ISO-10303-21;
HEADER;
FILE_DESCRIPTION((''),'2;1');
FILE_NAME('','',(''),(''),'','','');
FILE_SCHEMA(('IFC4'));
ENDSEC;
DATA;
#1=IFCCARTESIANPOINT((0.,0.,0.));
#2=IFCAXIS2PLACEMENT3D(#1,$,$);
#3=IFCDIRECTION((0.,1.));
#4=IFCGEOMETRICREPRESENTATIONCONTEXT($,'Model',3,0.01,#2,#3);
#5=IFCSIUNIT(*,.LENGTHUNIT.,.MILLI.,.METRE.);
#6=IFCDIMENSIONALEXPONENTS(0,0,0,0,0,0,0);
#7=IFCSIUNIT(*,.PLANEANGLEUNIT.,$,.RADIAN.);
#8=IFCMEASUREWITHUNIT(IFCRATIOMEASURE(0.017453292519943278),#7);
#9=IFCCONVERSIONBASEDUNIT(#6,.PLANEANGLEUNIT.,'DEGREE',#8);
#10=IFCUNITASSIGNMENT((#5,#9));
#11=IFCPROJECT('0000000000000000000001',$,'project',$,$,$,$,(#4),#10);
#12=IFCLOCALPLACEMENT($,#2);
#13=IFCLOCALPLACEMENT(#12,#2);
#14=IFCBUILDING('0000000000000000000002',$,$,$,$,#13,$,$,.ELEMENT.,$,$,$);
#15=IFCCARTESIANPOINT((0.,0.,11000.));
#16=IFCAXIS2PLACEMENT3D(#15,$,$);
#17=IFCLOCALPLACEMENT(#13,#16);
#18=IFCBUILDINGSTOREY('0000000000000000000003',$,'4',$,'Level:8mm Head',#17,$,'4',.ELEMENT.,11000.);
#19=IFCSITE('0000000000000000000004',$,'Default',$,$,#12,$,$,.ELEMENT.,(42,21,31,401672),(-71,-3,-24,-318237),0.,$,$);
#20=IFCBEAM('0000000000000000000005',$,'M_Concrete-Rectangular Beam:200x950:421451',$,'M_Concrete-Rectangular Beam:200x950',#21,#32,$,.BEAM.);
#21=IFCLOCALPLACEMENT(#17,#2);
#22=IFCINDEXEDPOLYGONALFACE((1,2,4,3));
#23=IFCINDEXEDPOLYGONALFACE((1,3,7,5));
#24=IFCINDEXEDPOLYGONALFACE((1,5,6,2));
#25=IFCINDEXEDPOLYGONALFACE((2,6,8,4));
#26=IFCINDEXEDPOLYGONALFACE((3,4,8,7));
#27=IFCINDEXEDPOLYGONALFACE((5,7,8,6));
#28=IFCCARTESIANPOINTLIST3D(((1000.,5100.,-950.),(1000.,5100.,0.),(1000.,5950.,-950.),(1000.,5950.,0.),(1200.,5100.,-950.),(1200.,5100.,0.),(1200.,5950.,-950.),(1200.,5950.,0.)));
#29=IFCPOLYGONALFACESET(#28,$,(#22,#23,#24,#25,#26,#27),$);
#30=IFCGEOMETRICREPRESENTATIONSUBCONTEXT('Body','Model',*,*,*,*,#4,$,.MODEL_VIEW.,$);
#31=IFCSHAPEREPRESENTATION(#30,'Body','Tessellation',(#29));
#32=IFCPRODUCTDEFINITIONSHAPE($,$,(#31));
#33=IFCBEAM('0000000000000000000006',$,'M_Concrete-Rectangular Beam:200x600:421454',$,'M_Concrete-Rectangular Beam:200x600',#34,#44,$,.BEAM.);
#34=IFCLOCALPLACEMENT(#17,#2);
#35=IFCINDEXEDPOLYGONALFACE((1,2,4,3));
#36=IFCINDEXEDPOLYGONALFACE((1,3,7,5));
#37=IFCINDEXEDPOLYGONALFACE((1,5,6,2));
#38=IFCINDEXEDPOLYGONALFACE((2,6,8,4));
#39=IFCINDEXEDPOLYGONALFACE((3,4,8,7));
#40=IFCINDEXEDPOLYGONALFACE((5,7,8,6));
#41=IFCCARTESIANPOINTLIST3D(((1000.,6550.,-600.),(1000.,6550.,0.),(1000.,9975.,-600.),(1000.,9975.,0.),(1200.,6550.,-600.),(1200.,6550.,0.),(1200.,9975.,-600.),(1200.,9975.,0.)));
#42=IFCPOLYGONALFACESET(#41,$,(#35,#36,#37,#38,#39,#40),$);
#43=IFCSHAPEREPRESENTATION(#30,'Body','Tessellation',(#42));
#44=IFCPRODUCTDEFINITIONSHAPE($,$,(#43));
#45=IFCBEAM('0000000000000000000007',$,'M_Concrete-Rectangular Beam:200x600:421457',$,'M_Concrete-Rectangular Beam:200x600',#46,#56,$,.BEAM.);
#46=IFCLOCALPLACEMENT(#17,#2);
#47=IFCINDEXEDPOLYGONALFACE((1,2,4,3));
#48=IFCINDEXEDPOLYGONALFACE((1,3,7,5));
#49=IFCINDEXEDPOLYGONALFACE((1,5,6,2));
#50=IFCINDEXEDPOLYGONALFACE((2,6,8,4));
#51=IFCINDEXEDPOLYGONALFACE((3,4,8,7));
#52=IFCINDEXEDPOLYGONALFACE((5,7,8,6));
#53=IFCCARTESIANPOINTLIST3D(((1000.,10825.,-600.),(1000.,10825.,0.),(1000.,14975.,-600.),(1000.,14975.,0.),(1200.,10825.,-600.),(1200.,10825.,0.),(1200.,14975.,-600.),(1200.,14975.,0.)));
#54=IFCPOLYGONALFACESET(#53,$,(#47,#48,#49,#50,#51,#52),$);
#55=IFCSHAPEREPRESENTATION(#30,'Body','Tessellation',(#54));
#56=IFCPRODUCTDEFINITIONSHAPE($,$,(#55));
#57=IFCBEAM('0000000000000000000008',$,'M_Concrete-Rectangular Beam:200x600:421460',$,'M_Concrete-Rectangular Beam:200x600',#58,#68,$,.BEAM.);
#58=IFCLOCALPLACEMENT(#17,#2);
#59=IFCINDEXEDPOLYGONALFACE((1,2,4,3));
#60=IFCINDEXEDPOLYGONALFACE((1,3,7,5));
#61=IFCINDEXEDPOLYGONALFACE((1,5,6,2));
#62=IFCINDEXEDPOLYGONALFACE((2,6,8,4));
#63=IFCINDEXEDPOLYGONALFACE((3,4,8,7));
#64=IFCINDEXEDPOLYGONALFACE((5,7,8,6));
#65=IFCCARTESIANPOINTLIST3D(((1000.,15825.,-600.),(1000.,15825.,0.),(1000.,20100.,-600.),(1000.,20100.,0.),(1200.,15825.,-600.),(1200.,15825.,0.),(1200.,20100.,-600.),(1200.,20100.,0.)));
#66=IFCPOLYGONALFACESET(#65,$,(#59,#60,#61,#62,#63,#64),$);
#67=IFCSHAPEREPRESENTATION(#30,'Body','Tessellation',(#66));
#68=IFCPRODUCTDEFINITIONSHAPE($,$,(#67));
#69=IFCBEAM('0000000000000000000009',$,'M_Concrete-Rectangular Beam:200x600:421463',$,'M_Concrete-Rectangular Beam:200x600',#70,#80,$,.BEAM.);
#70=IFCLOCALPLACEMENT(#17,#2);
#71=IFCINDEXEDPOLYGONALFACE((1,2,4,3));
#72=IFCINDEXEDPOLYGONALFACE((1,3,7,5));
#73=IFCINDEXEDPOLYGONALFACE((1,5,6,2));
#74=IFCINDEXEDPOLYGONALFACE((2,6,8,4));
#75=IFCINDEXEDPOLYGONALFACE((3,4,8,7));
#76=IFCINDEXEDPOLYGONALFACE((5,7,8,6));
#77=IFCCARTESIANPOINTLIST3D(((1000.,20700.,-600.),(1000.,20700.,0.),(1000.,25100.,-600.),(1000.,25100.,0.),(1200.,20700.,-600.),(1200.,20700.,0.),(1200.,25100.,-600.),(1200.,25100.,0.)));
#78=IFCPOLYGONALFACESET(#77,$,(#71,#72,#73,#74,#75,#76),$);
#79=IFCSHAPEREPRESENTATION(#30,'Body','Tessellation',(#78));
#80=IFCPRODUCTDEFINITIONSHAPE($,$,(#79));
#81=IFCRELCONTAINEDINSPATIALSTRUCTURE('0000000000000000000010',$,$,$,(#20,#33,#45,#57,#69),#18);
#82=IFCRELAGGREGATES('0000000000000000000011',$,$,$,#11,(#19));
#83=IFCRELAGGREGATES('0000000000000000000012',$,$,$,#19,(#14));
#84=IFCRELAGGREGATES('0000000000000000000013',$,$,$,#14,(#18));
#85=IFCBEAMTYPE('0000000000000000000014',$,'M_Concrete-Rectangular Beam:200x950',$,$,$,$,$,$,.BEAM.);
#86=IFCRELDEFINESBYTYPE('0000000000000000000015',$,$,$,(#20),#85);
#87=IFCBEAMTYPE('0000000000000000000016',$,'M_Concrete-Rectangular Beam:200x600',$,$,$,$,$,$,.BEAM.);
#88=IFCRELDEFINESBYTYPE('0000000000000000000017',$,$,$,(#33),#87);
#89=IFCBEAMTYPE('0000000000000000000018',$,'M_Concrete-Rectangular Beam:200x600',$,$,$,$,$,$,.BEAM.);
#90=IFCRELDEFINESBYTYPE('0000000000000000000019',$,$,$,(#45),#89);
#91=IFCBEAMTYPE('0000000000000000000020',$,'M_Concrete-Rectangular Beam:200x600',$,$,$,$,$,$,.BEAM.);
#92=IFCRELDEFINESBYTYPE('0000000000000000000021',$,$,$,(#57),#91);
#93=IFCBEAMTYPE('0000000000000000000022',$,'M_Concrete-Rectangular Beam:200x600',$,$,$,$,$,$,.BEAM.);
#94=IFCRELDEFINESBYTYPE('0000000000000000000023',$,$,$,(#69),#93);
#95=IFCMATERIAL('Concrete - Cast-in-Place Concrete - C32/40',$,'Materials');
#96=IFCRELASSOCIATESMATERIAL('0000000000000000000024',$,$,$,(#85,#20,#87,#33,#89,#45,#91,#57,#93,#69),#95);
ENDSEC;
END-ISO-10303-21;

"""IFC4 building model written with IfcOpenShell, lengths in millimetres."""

from ifc_helpers import new_model, entity, si_unit, converted_unit, direction, frame, origin, place, context, subcontext, project, spatial, indexed_curve, outline, extrude, source, transform, mapped, material, type_object, type_shapes, element, save


model = new_model("IFC4")

# Units and contexts
model_context = context("Model", 3, precision=0.01, world=origin(), true_north=direction((0.0, 1.0)))
body_context = subcontext(model_context, "Body", "Model", "MODEL_VIEW")
ifc_project = project(units=[si_unit("LENGTHUNIT", "METRE", prefix="MILLI"), converted_unit("PLANEANGLEUNIT", "DEGREE", entity("IfcRatioMeasure", 0.017453292519943278), si_unit("PLANEANGLEUNIT", "RADIAN"), dimensions=[0, 0, 0, 0, 0, 0, 0])], contexts=[model_context])

# Site, building, storey
site_placement = place(None, origin())
site = spatial("IfcSite", under=ifc_project, at=site_placement, Name="Default", CompositionType="ELEMENT", RefLatitude=(42, 21, 31, 401672), RefLongitude=(-71, -3, -24, -318237), RefElevation=0.0)
building_placement = place(site_placement, origin())
building = spatial("IfcBuilding", under=site, at=building_placement, CompositionType="ELEMENT")
storey_placement = place(building_placement, frame((0.0, 0.0, 11000.0)))
storey = spatial("IfcBuildingStorey", under=building, at=storey_placement, Name="4", ObjectType="Level:8mm Head", LongName="4", CompositionType="ELEMENT", Elevation=11000.0)

# Beams
ifc_material_1 = material(Name="Concrete - Cast-in-Place Concrete - C32/40", Category="Materials")
beam_type_1 = type_object("IfcBeamType", Name="M_Concrete-Rectangular Beam:200x950", PredefinedType="BEAM", material=ifc_material_1)
shared_shape_1 = source(origin(), body_context, "Body", "SweptSolid", [
    extrude(outline(indexed_curve([(-100.0, -475.0), (100.0, -475.0), (100.0, 475.0), (-100.0, 475.0), (-100.0, -475.0)], self_intersect=False)), frame((1100.0, 5100.0, 10525.0), z_axis=(0.0, 1.0, 0.0), x_axis=(-1.0, 0.0, 0.0)), (0.0, 0.0, 1.0), 850.0),
])
type_shapes(beam_type_1, [shared_shape_1])
beam_1_placement = place(storey_placement, frame((0.0, 0.0, -11000.0)))
element("IfcBeam", 1, at=beam_1_placement, inside=storey, type_object=beam_type_1, material=ifc_material_1, Name="M_Concrete-Rectangular Beam:200x950:421451", ObjectType="M_Concrete-Rectangular Beam:200x950", PredefinedType="BEAM", context=body_context, shape_type="MappedRepresentation", body=[
    mapped(shared_shape_1, transform((0.0, 0.0, 0.0), scale=1.0)),
])
beam_type_2 = type_object("IfcBeamType", Name="M_Concrete-Rectangular Beam:200x600", PredefinedType="BEAM", material=ifc_material_1)
shared_shape_2 = source(origin(), body_context, "Body", "SweptSolid", [
    extrude(outline(indexed_curve([(-100.0, -300.0), (100.0, -300.0), (100.0, 300.0), (-100.0, 300.0), (-100.0, -300.0)], self_intersect=False)), frame((1100.0, 6550.0, 10700.0), z_axis=(0.0, 1.0, 0.0), x_axis=(-1.0, 0.0, 0.0)), (0.0, 0.0, 1.0), 3425.0),
])
type_shapes(beam_type_2, [shared_shape_2])
beam_2_placement = place(storey_placement, frame((0.0, 0.0, -11000.0)))
element("IfcBeam", 2, at=beam_2_placement, inside=storey, type_object=beam_type_2, material=ifc_material_1, Name="M_Concrete-Rectangular Beam:200x600:421454", ObjectType="M_Concrete-Rectangular Beam:200x600", PredefinedType="BEAM", context=body_context, shape_type="MappedRepresentation", body=[
    mapped(shared_shape_2, transform((0.0, 0.0, 0.0), scale=1.0)),
])
beam_type_3 = type_object("IfcBeamType", Name="M_Concrete-Rectangular Beam:200x600", PredefinedType="BEAM", material=ifc_material_1)
shared_shape_3 = source(origin(), body_context, "Body", "SweptSolid", [
    extrude(outline(indexed_curve([(-100.0, -300.0), (100.0, -300.0), (100.0, 300.0), (-100.0, 300.0), (-100.0, -300.0)], self_intersect=False)), frame((1100.0, 10825.0, 10700.0), z_axis=(0.0, 1.0, 0.0), x_axis=(-1.0, 0.0, 0.0)), (0.0, 0.0, 1.0), 4150.0),
])
type_shapes(beam_type_3, [shared_shape_3])
beam_3_placement = place(storey_placement, frame((0.0, 0.0, -11000.0)))
element("IfcBeam", 3, at=beam_3_placement, inside=storey, type_object=beam_type_3, material=ifc_material_1, Name="M_Concrete-Rectangular Beam:200x600:421457", ObjectType="M_Concrete-Rectangular Beam:200x600", PredefinedType="BEAM", context=body_context, shape_type="MappedRepresentation", body=[
    mapped(shared_shape_3, transform((0.0, 0.0, 0.0), scale=1.0)),
])
beam_type_4 = type_object("IfcBeamType", Name="M_Concrete-Rectangular Beam:200x600", PredefinedType="BEAM", material=ifc_material_1)
shared_shape_4 = source(origin(), body_context, "Body", "SweptSolid", [
    extrude(outline(indexed_curve([(-100.0, -300.0), (100.0, -300.0), (100.0, 300.0), (-100.0, 300.0), (-100.0, -300.0)], self_intersect=False)), frame((1100.0, 15825.0, 10700.0), z_axis=(0.0, 1.0, 0.0), x_axis=(-1.0, 0.0, 0.0)), (0.0, 0.0, 1.0), 4275.0),
])
type_shapes(beam_type_4, [shared_shape_4])
beam_4_placement = place(storey_placement, frame((0.0, 0.0, -11000.0)))
element("IfcBeam", 4, at=beam_4_placement, inside=storey, type_object=beam_type_4, material=ifc_material_1, Name="M_Concrete-Rectangular Beam:200x600:421460", ObjectType="M_Concrete-Rectangular Beam:200x600", PredefinedType="BEAM", context=body_context, shape_type="MappedRepresentation", body=[
    mapped(shared_shape_4, transform((0.0, 0.0, 0.0), scale=1.0)),
])
beam_type_5 = type_object("IfcBeamType", Name="M_Concrete-Rectangular Beam:200x600", PredefinedType="BEAM", material=ifc_material_1)
shared_shape_5 = source(origin(), body_context, "Body", "SweptSolid", [
    extrude(outline(indexed_curve([(-100.0, -300.0), (100.0, -300.0), (100.0, 300.0), (-100.0, 300.0), (-100.0, -300.0)], self_intersect=False)), frame((1100.0, 20700.0, 10700.0), z_axis=(0.0, 1.0, 0.0), x_axis=(-1.0, 0.0, 0.0)), (0.0, 0.0, 1.0), 4400.0),
])
type_shapes(beam_type_5, [shared_shape_5])
beam_5_placement = place(storey_placement, frame((0.0, 0.0, -11000.0)))
element("IfcBeam", 5, at=beam_5_placement, inside=storey, type_object=beam_type_5, material=ifc_material_1, Name="M_Concrete-Rectangular Beam:200x600:421463", ObjectType="M_Concrete-Rectangular Beam:200x600", PredefinedType="BEAM", context=body_context, shape_type="MappedRepresentation", body=[
    mapped(shared_shape_5, transform((0.0, 0.0, 0.0), scale=1.0)),
])

save(model, "model.ifc")
